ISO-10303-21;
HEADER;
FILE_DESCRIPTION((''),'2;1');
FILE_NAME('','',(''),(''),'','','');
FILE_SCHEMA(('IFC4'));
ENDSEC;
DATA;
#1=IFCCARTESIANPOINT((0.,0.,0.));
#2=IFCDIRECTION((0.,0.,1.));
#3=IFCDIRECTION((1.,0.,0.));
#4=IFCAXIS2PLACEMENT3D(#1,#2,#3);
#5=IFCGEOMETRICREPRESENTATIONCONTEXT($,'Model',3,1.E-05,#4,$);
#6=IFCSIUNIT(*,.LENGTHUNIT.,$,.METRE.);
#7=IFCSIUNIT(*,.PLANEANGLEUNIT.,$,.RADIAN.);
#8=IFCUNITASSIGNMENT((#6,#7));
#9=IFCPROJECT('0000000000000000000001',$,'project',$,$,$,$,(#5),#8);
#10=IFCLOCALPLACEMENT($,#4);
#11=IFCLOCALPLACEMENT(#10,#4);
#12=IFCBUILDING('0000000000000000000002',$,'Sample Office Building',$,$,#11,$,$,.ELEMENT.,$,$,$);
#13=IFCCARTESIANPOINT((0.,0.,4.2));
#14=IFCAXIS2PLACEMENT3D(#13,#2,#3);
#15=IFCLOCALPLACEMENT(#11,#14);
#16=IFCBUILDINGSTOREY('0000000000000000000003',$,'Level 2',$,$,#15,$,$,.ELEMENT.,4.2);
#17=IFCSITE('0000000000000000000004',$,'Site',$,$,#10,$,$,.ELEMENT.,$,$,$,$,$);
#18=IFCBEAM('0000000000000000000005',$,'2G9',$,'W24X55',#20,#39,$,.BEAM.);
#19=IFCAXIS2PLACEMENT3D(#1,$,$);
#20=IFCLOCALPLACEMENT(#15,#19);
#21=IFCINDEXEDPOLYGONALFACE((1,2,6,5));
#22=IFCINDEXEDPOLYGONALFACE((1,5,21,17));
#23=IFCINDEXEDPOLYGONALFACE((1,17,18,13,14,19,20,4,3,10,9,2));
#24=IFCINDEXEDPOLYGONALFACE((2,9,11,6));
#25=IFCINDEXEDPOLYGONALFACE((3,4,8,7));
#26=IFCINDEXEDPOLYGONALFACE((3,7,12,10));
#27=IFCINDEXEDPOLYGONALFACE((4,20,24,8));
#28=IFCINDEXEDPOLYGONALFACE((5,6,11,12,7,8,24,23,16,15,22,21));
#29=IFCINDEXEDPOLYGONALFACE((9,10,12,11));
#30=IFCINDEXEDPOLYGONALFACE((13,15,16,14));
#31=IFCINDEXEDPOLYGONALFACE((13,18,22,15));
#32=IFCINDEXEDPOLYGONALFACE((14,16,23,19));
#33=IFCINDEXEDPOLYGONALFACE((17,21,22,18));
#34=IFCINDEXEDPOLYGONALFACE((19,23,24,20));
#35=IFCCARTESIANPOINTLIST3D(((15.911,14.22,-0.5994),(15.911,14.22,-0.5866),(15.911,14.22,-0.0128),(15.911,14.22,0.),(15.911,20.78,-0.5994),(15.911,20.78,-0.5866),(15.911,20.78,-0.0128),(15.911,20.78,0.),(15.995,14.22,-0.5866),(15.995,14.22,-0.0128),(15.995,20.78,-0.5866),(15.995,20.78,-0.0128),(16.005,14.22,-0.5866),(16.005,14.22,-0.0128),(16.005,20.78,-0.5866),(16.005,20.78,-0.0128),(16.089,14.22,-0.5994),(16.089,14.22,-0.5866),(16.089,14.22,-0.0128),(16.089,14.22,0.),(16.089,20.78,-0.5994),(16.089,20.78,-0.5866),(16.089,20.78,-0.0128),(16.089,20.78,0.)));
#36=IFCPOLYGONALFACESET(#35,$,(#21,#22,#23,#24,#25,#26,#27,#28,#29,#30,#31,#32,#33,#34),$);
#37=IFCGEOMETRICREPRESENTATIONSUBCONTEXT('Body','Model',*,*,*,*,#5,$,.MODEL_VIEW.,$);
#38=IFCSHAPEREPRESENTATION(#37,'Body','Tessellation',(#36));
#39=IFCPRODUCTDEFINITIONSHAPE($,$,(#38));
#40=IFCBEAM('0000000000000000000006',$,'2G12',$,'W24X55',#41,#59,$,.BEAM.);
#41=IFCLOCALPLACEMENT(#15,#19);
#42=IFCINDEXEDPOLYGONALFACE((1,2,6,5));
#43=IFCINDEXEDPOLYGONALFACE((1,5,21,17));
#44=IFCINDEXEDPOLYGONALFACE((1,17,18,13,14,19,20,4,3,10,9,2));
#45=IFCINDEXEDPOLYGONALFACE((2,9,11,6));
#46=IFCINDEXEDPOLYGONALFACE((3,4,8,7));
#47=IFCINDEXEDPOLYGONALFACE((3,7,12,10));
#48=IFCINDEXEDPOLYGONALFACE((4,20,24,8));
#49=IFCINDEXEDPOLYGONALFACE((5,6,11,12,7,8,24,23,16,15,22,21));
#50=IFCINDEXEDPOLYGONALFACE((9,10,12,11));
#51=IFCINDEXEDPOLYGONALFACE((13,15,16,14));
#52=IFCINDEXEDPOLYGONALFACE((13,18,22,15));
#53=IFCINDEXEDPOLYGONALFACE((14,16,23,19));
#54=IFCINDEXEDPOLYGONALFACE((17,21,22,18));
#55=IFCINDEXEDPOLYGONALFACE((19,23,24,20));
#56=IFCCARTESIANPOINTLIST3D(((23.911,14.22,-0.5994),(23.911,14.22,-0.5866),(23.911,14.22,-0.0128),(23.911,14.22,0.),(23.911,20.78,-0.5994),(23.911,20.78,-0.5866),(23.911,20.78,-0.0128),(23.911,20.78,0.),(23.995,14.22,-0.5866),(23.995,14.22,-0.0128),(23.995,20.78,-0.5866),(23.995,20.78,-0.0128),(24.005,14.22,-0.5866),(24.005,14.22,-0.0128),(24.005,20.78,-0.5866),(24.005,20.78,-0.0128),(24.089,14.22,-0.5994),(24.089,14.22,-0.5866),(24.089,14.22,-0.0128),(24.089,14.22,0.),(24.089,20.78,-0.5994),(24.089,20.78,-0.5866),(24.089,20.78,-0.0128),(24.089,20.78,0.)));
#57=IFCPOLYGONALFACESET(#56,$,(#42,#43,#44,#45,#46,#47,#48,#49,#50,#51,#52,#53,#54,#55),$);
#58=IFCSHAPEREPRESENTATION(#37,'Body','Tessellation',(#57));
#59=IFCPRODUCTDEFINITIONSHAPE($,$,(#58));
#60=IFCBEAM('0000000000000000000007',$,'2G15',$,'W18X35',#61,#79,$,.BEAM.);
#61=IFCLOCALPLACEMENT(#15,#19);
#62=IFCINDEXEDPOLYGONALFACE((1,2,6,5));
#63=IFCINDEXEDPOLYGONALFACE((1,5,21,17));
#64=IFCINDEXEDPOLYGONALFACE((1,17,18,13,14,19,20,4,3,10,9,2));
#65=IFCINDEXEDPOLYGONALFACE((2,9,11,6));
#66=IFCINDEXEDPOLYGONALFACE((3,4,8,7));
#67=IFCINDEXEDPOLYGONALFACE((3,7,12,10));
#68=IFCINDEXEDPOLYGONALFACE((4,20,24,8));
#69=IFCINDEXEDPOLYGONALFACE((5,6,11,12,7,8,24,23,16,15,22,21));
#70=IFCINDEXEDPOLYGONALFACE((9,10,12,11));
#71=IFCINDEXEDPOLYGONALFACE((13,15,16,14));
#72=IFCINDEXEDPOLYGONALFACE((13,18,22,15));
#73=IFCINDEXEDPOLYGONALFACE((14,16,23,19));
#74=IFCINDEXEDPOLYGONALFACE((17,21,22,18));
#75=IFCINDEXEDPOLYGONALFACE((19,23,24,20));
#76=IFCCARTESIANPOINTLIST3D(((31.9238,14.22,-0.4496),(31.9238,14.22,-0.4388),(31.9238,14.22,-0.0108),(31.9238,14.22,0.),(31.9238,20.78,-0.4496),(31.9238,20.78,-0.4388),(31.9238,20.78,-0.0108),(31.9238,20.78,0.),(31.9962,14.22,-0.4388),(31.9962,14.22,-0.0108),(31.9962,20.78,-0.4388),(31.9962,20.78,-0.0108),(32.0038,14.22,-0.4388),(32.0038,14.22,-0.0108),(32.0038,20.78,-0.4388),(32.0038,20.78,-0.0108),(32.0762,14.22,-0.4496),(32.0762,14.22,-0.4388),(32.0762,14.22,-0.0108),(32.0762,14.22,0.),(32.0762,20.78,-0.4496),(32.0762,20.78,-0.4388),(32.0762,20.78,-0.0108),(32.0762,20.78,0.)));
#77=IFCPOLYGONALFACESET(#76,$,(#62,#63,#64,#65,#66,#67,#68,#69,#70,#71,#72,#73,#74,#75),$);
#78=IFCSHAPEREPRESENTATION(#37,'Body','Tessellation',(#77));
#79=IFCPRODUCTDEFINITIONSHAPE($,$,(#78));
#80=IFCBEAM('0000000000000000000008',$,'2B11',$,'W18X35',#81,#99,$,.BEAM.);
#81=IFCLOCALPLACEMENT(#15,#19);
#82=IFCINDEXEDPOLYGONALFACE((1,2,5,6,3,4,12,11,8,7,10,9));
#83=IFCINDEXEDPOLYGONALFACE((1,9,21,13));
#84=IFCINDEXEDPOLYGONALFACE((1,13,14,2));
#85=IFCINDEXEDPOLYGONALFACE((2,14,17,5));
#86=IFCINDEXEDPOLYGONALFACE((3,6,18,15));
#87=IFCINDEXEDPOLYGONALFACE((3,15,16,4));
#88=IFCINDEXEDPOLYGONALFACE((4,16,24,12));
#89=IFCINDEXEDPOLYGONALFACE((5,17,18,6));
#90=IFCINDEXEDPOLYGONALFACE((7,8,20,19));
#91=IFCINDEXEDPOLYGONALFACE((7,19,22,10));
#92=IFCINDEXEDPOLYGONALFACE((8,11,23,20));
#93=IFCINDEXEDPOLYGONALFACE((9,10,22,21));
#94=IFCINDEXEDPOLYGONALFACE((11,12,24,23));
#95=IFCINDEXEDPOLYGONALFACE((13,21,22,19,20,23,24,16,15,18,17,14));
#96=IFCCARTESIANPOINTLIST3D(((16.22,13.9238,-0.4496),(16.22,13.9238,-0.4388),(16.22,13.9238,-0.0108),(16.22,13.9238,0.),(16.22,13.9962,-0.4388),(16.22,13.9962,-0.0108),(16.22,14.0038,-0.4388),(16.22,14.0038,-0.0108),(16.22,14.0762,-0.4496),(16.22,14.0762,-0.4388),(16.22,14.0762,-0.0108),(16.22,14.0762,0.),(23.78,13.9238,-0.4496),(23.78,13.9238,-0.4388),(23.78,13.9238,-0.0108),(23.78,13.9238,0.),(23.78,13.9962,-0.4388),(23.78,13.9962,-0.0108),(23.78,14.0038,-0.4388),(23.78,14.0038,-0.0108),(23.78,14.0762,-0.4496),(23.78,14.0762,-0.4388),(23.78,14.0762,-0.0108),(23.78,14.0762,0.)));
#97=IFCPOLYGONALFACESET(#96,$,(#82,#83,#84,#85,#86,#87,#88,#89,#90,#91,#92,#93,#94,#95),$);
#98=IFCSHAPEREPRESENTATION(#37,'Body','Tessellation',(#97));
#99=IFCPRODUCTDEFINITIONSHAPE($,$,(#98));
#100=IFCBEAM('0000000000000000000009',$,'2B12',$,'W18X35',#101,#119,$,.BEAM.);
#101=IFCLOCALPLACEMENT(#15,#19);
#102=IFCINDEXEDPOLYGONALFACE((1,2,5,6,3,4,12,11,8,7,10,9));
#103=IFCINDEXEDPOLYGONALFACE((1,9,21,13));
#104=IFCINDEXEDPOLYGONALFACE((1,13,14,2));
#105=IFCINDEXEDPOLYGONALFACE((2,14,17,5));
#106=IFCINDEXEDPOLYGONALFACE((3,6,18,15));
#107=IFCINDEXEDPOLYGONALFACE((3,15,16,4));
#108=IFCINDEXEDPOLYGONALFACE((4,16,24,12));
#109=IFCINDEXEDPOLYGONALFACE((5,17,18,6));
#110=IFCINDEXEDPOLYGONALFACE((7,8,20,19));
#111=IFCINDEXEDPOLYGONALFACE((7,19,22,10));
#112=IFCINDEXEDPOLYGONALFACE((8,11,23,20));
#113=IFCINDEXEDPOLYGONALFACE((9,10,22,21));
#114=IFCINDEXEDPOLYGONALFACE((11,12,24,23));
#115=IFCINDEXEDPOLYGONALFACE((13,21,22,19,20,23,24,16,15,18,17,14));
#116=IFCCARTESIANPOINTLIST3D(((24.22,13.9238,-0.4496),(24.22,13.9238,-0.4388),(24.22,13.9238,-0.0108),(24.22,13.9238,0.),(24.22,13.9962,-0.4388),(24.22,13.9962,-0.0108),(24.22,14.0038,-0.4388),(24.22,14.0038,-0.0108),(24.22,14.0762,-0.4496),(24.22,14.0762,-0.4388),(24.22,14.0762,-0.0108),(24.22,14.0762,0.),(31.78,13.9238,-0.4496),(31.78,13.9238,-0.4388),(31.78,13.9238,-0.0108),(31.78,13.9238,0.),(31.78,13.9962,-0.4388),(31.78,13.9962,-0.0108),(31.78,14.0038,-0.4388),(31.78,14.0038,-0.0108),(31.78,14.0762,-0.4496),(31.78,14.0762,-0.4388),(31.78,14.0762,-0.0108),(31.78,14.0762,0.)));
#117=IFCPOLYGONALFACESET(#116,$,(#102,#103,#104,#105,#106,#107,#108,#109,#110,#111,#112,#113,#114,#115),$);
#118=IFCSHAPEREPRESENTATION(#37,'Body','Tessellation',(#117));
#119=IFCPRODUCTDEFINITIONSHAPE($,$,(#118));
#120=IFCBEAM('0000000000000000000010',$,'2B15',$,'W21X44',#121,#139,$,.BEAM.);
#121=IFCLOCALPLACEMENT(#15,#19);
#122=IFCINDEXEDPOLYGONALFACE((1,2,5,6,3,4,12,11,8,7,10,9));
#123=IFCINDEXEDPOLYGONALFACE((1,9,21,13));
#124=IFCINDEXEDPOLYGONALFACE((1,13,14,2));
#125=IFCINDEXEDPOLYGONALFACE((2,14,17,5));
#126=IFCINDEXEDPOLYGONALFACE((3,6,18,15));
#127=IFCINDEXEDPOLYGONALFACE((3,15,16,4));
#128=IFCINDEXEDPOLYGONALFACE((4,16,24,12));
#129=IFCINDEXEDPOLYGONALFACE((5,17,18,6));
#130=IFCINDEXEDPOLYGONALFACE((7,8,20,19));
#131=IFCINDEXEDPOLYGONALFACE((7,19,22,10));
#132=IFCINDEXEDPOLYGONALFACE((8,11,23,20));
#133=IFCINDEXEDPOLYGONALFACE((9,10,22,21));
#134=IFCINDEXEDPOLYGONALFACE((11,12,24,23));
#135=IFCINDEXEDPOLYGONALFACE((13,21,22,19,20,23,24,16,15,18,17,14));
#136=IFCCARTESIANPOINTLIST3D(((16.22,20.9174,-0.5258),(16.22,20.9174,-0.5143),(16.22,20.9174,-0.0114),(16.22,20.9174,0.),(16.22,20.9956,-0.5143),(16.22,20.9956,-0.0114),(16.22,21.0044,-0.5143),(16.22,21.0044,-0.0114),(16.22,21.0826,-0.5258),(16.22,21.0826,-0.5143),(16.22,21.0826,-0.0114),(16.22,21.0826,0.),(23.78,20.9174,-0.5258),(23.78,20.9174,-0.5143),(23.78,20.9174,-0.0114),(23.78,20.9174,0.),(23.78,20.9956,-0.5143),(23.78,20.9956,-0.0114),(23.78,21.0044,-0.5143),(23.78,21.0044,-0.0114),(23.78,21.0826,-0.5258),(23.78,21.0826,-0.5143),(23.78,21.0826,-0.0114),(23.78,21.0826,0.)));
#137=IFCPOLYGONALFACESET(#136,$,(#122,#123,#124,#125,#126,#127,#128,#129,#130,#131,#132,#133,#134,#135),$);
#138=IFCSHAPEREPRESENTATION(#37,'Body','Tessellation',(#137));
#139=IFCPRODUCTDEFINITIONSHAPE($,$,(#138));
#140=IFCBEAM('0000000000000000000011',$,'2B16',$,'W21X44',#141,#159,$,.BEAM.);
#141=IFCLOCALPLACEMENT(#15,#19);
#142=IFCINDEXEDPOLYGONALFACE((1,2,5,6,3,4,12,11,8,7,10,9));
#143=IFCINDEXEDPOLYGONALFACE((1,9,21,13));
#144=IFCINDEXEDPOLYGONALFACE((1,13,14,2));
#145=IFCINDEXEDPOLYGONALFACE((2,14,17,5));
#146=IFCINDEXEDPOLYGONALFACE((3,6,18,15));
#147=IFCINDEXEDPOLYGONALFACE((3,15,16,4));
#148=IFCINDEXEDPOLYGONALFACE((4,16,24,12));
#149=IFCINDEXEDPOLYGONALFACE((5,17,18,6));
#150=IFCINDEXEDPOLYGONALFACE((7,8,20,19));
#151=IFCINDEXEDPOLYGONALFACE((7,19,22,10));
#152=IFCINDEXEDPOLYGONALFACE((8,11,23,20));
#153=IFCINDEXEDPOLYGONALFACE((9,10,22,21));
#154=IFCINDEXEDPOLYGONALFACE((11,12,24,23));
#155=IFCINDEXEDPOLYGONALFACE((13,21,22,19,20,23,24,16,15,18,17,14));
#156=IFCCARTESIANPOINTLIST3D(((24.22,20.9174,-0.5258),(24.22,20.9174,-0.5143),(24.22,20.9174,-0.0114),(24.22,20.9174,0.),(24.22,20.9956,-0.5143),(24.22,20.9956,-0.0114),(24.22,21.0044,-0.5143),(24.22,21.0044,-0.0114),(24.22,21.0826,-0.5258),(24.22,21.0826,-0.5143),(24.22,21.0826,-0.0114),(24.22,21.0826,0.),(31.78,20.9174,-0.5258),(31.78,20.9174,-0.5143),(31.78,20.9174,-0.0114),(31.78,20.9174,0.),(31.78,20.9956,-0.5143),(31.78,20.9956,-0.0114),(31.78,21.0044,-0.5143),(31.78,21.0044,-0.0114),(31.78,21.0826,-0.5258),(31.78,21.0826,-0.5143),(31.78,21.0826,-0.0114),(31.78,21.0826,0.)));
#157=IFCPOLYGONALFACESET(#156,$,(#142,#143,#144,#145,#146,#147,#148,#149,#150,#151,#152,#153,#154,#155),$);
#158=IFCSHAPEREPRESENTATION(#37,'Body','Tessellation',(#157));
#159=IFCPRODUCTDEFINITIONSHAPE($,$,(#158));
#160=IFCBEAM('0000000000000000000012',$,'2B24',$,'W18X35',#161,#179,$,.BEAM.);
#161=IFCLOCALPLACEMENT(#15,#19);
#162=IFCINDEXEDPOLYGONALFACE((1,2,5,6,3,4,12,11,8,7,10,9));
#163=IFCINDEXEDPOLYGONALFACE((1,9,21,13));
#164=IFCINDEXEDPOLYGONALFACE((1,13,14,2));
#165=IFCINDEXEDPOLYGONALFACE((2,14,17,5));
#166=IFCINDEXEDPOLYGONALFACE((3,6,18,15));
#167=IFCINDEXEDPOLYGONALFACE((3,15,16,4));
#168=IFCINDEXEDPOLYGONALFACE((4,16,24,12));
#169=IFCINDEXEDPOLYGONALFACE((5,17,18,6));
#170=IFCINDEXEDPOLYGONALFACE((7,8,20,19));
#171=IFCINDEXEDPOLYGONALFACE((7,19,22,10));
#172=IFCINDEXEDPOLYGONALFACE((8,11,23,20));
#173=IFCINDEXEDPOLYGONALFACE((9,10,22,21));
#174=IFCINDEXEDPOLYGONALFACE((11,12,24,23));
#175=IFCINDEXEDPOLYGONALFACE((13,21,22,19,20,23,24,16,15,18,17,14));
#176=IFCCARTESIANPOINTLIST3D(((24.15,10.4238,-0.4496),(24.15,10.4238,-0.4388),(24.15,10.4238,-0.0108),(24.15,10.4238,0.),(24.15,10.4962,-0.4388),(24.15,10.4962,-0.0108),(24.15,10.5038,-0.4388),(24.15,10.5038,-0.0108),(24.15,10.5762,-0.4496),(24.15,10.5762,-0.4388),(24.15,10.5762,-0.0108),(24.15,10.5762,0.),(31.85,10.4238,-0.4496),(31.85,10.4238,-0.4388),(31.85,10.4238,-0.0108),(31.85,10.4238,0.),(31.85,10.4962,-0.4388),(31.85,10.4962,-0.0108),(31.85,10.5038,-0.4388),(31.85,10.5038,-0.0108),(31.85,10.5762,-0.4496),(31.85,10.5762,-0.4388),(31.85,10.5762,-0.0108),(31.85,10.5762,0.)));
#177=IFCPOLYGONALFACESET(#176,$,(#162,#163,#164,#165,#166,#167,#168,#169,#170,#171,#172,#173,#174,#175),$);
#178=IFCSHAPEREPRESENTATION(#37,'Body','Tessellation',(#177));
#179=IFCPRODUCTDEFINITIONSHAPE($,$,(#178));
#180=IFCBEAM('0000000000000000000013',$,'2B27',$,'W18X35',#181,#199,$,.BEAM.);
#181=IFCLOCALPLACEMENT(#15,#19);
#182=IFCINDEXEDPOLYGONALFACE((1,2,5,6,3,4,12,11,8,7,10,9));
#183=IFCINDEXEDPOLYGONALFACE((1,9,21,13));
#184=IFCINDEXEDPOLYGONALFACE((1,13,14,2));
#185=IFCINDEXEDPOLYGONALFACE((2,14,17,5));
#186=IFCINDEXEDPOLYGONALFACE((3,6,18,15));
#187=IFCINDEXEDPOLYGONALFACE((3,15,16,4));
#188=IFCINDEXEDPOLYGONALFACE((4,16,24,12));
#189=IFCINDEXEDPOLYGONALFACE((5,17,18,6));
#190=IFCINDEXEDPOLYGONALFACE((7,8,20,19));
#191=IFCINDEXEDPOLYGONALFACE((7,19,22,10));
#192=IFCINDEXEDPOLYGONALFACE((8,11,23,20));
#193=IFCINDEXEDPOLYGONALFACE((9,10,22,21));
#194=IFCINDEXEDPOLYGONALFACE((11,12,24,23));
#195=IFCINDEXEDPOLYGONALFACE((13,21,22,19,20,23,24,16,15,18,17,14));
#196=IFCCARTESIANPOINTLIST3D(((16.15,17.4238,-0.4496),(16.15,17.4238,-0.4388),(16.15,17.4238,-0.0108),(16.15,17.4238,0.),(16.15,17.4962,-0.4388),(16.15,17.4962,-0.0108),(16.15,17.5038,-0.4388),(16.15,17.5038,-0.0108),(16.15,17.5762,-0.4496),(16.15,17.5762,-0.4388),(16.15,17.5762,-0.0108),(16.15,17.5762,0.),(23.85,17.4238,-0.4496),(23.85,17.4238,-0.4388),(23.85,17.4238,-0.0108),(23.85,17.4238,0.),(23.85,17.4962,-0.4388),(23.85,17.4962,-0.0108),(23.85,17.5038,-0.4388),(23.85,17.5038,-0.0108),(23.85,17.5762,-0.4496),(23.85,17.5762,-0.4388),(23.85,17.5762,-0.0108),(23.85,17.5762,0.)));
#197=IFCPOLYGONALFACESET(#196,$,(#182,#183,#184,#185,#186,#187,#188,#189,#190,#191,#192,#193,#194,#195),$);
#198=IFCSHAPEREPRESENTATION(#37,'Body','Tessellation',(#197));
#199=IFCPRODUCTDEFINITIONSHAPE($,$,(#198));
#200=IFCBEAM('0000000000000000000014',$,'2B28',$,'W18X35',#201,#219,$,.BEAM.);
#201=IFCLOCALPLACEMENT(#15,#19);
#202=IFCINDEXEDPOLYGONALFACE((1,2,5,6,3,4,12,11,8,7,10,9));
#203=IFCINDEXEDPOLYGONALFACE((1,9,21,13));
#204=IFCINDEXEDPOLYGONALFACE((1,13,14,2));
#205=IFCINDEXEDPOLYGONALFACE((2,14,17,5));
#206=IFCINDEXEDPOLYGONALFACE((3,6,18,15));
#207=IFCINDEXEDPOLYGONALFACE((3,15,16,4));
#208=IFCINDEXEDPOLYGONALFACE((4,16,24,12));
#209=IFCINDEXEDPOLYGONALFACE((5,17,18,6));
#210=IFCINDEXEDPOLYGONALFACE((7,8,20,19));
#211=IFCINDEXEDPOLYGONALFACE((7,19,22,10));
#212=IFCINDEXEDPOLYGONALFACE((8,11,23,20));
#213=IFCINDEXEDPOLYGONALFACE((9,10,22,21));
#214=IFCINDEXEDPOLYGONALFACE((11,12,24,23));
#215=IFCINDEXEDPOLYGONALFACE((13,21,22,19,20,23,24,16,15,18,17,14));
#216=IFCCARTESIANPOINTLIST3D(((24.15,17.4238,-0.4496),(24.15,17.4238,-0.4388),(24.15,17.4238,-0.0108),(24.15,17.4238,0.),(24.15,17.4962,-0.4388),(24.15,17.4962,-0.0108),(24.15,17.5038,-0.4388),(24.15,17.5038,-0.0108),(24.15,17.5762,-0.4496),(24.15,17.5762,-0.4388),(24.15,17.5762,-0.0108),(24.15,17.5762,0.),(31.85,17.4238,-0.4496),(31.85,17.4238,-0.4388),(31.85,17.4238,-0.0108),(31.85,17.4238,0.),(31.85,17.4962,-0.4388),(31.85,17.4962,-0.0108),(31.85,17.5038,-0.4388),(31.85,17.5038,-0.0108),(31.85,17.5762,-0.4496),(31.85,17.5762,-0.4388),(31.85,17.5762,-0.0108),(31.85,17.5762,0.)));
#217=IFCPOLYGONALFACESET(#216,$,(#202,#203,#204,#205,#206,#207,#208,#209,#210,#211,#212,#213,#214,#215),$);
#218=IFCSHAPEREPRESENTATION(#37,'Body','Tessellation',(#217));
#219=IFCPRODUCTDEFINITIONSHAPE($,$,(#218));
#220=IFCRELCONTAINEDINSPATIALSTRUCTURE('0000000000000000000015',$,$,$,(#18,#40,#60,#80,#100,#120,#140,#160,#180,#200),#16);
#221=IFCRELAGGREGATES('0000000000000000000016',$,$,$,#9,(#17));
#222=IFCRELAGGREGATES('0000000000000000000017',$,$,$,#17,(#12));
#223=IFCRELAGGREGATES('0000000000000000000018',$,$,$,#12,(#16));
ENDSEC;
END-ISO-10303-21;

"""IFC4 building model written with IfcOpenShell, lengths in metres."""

from ifc_helpers import new_model, si_unit, frame, origin_with_axes, place, context, subcontext, project, spatial, i_section, extrude, element, save


model = new_model("IFC4")

# Units and contexts
model_context = context("Model", 3, precision=1e-05, world=origin_with_axes())
body_context = subcontext(model_context, "Body", "Model", "MODEL_VIEW")
ifc_project = project(units=[si_unit("LENGTHUNIT", "METRE"), si_unit("PLANEANGLEUNIT", "RADIAN")], contexts=[model_context])

# Site, building, storey
site_placement = place(None, origin_with_axes())
site = spatial("IfcSite", under=ifc_project, at=site_placement, Name="Site", CompositionType="ELEMENT")
building_placement = place(site_placement, origin_with_axes())
building = spatial("IfcBuilding", under=site, at=building_placement, Name="Sample Office Building", CompositionType="ELEMENT")
storey_placement = place(building_placement, frame((0.0, 0.0, 4.2), z_axis=(0.0, 0.0, 1.0), x_axis=(1.0, 0.0, 0.0)))
storey = spatial("IfcBuildingStorey", under=building, at=storey_placement, Name="Level 2", CompositionType="ELEMENT", Elevation=4.2)

# Beams
for number, where, z_axis, x_axis, name in (
    (1, (16.0, 14.22, 3.9003), (0.0, 1.0, 0.0), (-1.0, 0.0, 0.0), "2G9"),
    (2, (24.0, 14.22, 3.9003), (0.0, 1.0, 0.0), (-1.0, 0.0, 0.0), "2G12"),
):
    element("IfcBeam", number, at=place(None, frame(where, z_axis=z_axis, x_axis=x_axis)), inside=storey, Name=name, ObjectType="W24X55", PredefinedType="BEAM", context=body_context, shape_type="SweptSolid", body=[
        extrude(i_section(OverallWidth=0.1781, OverallDepth=0.5994, WebThickness=0.01, FlangeThickness=0.0128), None, (0.0, 0.0, 1.0), 6.56),
    ])
beam_placement = place(None, frame((32.0, 14.22, 3.9752), z_axis=(0.0, 1.0, 0.0), x_axis=(-1.0, 0.0, 0.0)))
element("IfcBeam", 3, at=beam_placement, inside=storey, Name="2G15", ObjectType="W18X35", PredefinedType="BEAM", context=body_context, shape_type="SweptSolid", body=[
    extrude(i_section(OverallWidth=0.1524, OverallDepth=0.4496, WebThickness=0.0076, FlangeThickness=0.0108), None, (0.0, 0.0, 1.0), 6.56),
])
for number, where, z_axis, x_axis, name in (
    (4, (16.22, 14.0, 3.9752), (1.0, 0.0, 0.0), (0.0, 1.0, 0.0), "2B11"),
    (5, (24.22, 14.0, 3.9752), (1.0, 0.0, 0.0), (0.0, 1.0, 0.0), "2B12"),
):
    element("IfcBeam", number, at=place(None, frame(where, z_axis=z_axis, x_axis=x_axis)), inside=storey, Name=name, ObjectType="W18X35", PredefinedType="BEAM", context=body_context, shape_type="SweptSolid", body=[
        extrude(i_section(OverallWidth=0.1524, OverallDepth=0.4496, WebThickness=0.0076, FlangeThickness=0.0108), None, (0.0, 0.0, 1.0), 7.56),
    ])
for number, where, z_axis, x_axis, name in (
    (6, (16.22, 21.0, 3.9371), (1.0, 0.0, 0.0), (0.0, 1.0, 0.0), "2B15"),
    (7, (24.22, 21.0, 3.9371), (1.0, 0.0, 0.0), (0.0, 1.0, 0.0), "2B16"),
):
    element("IfcBeam", number, at=place(None, frame(where, z_axis=z_axis, x_axis=x_axis)), inside=storey, Name=name, ObjectType="W21X44", PredefinedType="BEAM", context=body_context, shape_type="SweptSolid", body=[
        extrude(i_section(OverallWidth=0.1651, OverallDepth=0.5258, WebThickness=0.0089, FlangeThickness=0.0114), None, (0.0, 0.0, 1.0), 7.56),
    ])
for number, where, z_axis, x_axis, name in (
    (8, (24.15, 10.5, 3.9752), (1.0, 0.0, 0.0), (0.0, 1.0, 0.0), "2B24"),
    (9, (16.15, 17.5, 3.9752), (1.0, 0.0, 0.0), (0.0, 1.0, 0.0), "2B27"),
    (10, (24.15, 17.5, 3.9752), (1.0, 0.0, 0.0), (0.0, 1.0, 0.0), "2B28"),
):
    element("IfcBeam", number, at=place(None, frame(where, z_axis=z_axis, x_axis=x_axis)), inside=storey, Name=name, ObjectType="W18X35", PredefinedType="BEAM", context=body_context, shape_type="SweptSolid", body=[
        extrude(i_section(OverallWidth=0.1524, OverallDepth=0.4496, WebThickness=0.0076, FlangeThickness=0.0108), None, (0.0, 0.0, 1.0), 7.7),
    ])

save(model, "model.ifc")
